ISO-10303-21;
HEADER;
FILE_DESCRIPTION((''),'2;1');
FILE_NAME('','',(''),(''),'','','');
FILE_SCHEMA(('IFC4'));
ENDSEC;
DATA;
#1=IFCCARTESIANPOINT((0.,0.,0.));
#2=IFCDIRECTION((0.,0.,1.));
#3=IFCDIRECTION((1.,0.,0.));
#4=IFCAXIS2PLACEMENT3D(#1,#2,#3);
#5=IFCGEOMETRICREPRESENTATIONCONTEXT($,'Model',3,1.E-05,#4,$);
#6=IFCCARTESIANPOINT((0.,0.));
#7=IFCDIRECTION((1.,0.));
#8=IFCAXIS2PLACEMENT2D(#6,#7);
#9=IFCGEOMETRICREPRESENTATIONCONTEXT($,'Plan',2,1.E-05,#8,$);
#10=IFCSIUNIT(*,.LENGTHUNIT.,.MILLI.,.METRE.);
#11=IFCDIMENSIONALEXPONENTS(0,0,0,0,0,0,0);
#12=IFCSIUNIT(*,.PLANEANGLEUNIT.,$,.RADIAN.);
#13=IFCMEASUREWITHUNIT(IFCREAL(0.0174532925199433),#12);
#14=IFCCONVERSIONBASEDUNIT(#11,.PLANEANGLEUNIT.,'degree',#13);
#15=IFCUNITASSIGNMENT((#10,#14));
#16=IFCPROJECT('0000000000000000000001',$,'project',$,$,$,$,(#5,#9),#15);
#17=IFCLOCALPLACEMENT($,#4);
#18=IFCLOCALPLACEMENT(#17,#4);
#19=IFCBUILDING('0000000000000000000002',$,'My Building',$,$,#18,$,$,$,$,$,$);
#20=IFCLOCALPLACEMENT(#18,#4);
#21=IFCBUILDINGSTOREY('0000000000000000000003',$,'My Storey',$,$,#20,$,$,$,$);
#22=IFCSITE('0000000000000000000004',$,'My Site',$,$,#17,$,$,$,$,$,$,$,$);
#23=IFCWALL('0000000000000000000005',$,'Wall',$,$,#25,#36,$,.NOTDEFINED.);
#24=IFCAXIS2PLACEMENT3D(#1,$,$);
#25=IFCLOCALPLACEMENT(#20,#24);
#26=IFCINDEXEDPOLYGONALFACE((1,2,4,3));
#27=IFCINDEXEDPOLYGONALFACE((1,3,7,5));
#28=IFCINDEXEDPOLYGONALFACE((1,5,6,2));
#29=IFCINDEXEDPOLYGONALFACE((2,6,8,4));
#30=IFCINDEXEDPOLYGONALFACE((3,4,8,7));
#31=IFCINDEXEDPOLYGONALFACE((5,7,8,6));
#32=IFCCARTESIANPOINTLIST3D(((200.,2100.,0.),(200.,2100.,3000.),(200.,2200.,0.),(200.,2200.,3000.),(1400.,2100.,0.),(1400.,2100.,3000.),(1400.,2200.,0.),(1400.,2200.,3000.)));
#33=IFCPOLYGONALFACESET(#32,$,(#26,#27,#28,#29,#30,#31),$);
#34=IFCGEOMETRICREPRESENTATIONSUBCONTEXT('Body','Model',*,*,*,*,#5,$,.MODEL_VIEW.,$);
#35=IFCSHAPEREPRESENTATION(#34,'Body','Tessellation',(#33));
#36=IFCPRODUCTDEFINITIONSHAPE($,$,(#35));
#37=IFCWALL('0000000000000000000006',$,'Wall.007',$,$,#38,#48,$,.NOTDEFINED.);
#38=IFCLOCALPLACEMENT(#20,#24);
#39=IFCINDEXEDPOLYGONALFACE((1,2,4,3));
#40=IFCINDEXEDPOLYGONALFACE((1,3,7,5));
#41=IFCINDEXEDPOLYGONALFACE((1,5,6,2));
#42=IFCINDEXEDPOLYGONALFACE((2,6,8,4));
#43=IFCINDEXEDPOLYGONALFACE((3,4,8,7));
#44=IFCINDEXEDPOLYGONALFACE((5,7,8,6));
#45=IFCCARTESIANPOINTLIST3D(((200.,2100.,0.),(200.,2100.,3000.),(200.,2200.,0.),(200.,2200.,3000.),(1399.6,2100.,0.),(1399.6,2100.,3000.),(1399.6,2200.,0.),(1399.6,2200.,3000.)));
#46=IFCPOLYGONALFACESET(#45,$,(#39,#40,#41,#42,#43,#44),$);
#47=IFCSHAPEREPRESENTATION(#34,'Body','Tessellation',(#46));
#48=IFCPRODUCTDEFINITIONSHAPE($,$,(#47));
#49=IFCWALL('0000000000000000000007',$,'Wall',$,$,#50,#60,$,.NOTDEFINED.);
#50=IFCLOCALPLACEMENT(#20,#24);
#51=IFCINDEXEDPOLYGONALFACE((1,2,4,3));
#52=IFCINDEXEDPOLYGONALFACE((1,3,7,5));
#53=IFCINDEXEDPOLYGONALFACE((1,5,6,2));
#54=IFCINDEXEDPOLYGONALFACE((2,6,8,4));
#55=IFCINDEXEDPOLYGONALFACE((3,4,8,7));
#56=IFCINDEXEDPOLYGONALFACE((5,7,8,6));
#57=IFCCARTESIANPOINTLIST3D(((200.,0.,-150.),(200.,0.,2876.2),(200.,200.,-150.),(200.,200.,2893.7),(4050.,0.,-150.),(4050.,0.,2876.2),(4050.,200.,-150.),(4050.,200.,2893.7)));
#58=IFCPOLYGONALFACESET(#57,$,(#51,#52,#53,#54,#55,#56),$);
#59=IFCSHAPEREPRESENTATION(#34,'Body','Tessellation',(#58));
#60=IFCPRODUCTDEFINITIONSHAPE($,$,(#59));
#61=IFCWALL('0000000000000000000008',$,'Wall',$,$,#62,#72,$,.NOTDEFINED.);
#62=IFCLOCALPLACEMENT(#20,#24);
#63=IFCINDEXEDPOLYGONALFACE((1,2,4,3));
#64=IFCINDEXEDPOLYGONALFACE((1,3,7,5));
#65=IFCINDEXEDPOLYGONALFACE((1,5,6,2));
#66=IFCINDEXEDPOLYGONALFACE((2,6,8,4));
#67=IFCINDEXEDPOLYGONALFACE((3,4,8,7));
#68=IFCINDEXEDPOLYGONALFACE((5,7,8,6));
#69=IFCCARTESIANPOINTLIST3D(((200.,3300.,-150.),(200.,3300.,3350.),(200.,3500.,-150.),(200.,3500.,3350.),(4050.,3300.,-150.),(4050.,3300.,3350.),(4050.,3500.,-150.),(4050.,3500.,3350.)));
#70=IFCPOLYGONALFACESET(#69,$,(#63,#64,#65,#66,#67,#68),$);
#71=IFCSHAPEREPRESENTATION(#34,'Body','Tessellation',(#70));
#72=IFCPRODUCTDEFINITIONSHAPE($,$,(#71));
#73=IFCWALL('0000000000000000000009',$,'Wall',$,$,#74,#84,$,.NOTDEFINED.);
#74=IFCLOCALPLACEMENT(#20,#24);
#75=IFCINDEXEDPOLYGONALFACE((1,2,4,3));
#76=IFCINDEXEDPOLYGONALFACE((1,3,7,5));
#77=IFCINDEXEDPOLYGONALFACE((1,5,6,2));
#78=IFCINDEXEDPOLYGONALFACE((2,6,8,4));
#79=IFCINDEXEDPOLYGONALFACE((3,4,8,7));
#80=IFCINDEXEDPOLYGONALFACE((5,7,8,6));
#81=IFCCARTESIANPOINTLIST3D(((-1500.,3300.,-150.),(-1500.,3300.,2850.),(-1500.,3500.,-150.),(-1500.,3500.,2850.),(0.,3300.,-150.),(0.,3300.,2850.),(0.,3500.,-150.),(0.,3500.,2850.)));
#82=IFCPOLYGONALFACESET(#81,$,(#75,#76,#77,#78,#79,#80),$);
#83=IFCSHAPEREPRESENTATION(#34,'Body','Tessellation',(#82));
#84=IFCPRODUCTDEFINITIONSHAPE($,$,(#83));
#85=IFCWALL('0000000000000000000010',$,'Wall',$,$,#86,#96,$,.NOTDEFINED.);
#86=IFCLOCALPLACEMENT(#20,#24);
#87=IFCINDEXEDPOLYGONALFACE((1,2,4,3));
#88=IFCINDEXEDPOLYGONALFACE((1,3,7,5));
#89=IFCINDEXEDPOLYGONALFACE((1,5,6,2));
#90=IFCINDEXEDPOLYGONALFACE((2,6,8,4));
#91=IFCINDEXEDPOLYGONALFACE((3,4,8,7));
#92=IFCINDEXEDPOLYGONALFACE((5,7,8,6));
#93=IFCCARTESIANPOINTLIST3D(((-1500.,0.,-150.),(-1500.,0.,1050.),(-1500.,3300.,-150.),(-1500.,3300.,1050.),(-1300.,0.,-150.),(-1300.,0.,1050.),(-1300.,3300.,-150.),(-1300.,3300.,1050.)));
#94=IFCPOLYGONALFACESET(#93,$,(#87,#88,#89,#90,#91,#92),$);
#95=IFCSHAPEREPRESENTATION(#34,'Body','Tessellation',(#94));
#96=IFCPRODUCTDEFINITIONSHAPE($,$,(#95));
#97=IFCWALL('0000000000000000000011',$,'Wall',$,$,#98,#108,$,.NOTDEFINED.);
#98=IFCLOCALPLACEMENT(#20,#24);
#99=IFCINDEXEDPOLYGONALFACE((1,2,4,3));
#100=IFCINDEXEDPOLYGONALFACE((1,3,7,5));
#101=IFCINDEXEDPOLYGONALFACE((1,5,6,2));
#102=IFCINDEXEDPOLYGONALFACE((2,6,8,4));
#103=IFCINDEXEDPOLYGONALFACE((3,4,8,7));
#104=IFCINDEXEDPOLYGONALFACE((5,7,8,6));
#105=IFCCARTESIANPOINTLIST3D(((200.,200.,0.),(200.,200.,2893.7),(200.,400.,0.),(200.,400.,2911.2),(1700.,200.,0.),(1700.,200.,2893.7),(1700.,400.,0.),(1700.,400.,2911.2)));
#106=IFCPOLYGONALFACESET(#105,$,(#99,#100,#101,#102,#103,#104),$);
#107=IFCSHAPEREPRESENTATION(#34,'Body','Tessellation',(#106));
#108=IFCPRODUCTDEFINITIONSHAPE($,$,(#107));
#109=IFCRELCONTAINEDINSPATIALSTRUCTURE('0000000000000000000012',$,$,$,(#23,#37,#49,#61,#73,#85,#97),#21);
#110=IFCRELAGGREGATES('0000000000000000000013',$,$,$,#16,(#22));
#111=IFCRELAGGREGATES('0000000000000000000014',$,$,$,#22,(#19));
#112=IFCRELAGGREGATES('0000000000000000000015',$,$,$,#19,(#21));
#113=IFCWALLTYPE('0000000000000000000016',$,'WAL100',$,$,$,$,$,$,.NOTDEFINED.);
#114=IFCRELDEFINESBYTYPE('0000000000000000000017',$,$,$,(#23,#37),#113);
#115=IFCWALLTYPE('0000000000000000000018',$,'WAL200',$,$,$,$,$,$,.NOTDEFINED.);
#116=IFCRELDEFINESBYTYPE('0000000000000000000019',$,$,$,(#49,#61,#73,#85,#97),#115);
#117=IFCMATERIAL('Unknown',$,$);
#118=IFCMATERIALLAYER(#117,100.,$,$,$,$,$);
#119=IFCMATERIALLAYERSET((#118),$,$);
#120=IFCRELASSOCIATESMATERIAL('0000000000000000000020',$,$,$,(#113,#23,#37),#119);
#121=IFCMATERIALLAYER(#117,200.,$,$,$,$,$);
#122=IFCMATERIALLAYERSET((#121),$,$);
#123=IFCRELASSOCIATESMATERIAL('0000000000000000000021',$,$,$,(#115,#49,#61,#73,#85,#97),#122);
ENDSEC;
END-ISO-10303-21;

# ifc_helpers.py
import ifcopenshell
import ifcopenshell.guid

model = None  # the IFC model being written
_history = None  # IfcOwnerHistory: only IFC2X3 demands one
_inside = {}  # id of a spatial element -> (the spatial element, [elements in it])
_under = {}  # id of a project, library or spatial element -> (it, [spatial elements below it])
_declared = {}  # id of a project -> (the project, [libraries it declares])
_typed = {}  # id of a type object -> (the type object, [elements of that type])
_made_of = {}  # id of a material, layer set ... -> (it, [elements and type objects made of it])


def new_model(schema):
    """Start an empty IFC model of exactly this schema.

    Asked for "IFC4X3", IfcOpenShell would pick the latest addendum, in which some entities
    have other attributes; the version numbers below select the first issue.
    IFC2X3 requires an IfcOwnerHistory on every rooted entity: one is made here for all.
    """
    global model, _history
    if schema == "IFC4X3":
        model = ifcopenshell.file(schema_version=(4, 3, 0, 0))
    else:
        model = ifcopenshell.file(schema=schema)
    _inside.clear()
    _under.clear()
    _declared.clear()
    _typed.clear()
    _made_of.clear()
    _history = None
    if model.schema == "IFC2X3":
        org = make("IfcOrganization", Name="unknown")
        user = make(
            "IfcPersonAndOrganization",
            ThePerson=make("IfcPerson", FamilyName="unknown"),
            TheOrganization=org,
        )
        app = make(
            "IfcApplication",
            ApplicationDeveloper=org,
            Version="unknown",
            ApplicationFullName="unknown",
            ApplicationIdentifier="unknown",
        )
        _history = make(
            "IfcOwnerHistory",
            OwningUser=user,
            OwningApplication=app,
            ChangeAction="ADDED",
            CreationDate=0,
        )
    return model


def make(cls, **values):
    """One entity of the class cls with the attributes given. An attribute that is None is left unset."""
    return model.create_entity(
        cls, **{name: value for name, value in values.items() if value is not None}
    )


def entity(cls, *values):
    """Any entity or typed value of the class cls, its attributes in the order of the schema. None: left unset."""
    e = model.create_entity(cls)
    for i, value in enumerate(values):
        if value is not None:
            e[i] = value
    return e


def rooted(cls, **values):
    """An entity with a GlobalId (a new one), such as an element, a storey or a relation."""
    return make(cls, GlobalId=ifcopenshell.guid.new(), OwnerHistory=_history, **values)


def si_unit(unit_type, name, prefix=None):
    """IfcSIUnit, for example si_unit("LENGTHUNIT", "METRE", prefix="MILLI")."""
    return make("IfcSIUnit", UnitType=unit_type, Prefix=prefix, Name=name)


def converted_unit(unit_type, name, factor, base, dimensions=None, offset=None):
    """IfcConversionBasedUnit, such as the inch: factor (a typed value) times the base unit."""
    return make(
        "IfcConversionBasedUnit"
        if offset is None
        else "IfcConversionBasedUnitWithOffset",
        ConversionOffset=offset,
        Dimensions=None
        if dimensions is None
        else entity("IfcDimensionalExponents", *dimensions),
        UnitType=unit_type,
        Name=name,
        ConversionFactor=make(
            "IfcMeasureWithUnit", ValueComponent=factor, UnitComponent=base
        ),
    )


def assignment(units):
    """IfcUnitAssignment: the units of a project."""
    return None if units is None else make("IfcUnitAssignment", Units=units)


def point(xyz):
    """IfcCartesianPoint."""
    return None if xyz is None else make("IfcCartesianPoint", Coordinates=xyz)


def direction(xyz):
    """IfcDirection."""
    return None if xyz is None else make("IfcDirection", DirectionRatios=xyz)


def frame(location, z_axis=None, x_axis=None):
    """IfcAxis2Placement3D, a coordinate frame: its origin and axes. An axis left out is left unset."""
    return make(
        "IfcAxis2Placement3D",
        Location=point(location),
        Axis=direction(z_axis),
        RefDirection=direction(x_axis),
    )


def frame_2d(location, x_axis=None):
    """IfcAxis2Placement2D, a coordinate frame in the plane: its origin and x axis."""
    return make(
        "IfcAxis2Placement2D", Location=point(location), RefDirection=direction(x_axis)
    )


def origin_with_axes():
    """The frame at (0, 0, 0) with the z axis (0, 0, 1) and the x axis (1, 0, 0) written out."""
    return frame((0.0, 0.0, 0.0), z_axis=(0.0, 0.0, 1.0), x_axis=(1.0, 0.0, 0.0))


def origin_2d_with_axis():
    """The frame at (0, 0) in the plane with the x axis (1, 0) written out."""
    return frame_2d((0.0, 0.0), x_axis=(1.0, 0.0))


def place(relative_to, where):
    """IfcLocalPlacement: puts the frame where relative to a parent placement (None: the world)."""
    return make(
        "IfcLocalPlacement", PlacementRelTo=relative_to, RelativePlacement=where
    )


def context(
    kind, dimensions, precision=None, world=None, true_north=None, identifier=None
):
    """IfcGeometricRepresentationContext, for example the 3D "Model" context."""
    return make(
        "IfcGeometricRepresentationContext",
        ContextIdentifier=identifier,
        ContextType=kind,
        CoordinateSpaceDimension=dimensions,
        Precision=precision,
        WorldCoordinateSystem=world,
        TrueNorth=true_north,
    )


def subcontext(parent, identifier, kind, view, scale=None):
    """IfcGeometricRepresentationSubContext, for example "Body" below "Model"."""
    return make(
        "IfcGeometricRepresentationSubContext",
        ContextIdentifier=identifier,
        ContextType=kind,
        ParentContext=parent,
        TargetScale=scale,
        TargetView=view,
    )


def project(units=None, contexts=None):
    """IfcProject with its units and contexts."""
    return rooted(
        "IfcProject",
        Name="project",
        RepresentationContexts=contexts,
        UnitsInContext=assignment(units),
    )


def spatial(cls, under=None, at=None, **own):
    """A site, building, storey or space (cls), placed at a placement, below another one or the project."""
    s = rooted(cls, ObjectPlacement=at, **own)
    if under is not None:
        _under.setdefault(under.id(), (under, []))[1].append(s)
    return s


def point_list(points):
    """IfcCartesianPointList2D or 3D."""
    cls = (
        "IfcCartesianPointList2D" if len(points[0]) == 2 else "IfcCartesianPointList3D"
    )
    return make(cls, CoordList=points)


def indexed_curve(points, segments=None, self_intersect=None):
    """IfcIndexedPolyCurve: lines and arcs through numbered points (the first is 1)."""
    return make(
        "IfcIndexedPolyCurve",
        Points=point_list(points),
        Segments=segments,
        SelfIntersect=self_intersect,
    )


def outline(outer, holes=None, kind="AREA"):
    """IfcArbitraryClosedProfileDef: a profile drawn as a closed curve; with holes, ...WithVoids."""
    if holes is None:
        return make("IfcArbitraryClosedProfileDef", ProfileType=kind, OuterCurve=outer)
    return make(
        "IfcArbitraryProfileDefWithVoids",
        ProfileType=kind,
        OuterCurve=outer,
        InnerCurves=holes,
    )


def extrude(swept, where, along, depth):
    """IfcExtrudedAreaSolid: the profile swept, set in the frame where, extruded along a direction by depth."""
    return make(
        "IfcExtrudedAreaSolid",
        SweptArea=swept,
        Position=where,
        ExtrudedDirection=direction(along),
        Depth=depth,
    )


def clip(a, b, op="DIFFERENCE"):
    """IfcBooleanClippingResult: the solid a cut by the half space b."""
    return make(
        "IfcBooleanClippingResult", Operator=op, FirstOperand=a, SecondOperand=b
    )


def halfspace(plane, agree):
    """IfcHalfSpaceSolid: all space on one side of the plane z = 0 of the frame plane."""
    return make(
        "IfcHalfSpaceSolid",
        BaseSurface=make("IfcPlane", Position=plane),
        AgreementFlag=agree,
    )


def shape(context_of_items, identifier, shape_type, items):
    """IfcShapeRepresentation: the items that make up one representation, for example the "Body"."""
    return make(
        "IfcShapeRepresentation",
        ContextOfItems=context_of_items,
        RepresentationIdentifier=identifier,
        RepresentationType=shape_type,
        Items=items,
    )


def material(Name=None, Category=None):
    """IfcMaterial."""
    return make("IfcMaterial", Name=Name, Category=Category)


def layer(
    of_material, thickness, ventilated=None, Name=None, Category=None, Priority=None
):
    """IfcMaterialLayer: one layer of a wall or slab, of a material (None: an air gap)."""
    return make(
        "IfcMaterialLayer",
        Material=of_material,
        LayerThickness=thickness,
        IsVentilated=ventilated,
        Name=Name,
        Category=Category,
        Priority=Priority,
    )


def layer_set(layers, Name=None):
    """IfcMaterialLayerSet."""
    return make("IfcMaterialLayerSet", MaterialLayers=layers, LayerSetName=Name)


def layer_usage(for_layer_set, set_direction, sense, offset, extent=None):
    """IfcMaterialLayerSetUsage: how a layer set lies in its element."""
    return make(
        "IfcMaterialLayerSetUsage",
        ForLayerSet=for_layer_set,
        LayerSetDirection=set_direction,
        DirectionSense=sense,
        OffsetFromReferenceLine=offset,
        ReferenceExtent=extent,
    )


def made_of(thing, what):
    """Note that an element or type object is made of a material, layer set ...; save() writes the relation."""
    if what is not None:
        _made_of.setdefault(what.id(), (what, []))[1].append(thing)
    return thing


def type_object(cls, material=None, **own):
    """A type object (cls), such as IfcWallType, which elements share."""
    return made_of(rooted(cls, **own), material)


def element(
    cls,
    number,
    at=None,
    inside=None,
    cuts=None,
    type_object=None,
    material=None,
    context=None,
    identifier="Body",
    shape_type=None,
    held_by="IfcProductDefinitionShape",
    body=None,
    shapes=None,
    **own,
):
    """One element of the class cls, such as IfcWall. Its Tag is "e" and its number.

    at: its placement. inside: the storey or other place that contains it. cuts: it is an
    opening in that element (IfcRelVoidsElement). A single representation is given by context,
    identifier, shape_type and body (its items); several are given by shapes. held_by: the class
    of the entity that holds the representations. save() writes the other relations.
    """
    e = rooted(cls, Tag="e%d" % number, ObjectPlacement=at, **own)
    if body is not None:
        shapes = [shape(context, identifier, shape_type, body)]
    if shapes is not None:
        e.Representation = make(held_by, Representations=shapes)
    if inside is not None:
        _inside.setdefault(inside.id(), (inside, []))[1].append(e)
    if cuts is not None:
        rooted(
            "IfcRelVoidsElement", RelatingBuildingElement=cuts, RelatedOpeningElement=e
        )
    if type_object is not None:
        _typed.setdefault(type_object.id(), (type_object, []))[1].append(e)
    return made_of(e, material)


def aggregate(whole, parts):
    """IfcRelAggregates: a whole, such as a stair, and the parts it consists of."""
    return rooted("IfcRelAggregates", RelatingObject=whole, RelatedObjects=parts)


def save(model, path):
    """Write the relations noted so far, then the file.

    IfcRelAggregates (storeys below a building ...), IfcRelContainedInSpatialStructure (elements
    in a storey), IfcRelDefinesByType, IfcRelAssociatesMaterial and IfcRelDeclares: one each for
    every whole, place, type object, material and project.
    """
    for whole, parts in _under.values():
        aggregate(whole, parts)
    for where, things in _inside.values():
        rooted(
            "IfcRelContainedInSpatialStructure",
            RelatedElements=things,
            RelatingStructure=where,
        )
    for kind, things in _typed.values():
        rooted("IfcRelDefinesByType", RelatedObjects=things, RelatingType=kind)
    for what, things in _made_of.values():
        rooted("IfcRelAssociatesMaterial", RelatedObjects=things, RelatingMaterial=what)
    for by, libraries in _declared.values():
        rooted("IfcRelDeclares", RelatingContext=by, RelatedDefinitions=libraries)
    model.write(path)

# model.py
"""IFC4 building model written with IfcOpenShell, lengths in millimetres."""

from ifc_helpers import new_model, entity, si_unit, converted_unit, frame, origin_with_axes, origin_2d_with_axis, place, context, subcontext, project, spatial, indexed_curve, outline, extrude, clip, halfspace, material, layer, layer_set, layer_usage, type_object, element, save


model = new_model("IFC4")

# Units and contexts
model_context = context("Model", 3, precision=1e-05, world=origin_with_axes())
plan_context = context("Plan", 2, precision=1e-05, world=origin_2d_with_axis())
body_context = subcontext(model_context, "Body", "Model", "MODEL_VIEW")
ifc_project = project(units=[si_unit("LENGTHUNIT", "METRE", prefix="MILLI"), converted_unit("PLANEANGLEUNIT", "degree", entity("IfcReal", 0.0174532925199433), si_unit("PLANEANGLEUNIT", "RADIAN"), dimensions=[0, 0, 0, 0, 0, 0, 0])], contexts=[model_context, plan_context])

# Site, building, storey
site_placement = place(None, origin_with_axes())
site = spatial("IfcSite", under=ifc_project, at=site_placement, Name="My Site")
building_placement = place(site_placement, origin_with_axes())
building = spatial("IfcBuilding", under=site, at=building_placement, Name="My Building")
storey_placement = place(building_placement, origin_with_axes())
storey = spatial("IfcBuildingStorey", under=building, at=storey_placement, Name="My Storey")

# Shared definitions
ifc_material = material(Name="Unknown")

# Walls
ifc_layer_1 = layer(ifc_material, 100.0)
ifc_layer_set_1 = layer_set([ifc_layer_1])
ifc_layer_usage_1 = layer_usage(ifc_layer_set_1, "AXIS2", "POSITIVE", 0.0)
wall_type_1 = type_object("IfcWallType", Name="WAL100", PredefinedType="NOTDEFINED", material=ifc_layer_set_1)
wall_1_placement = place(storey_placement, frame((200.0, 2100.0, 0.0), z_axis=(0.0, 0.0, 1.0), x_axis=(1.0, 0.0, 0.0)))
element("IfcWall", 1, at=wall_1_placement, inside=storey, type_object=wall_type_1, material=ifc_layer_usage_1, Name="Wall", PredefinedType="NOTDEFINED", context=body_context, shape_type="SweptSolid", body=[
    extrude(outline(indexed_curve([(0.0, 0.0), (0.0, 100.0), (1200.0, 100.0), (1200.0, 0.0), (0.0, 0.0)], self_intersect=False)), origin_with_axes(), (0.0, 0.0, 1.0), 3000.0),
])
ifc_layer_usage_2 = layer_usage(ifc_layer_set_1, "AXIS2", "POSITIVE", 0.0)
wall_2_placement = place(storey_placement, frame((1399.6, 2200.0, 0.0), z_axis=(0.0, 0.0, 1.0), x_axis=(-1.0, 0.0, 0.0)))
element("IfcWall", 2, at=wall_2_placement, inside=storey, type_object=wall_type_1, material=ifc_layer_usage_2, Name="Wall.007", PredefinedType="NOTDEFINED", context=body_context, shape_type="SweptSolid", body=[
    extrude(outline(indexed_curve([(0.0, 0.0), (0.0, 100.0), (1199.6, 100.0), (1199.6, 0.0), (0.0, 0.0)], self_intersect=False)), origin_with_axes(), (0.0, 0.0, 1.0), 3000.0),
])
ifc_layer_2 = layer(ifc_material, 200.0)
ifc_layer_set_2 = layer_set([ifc_layer_2])
ifc_layer_usage_3 = layer_usage(ifc_layer_set_2, "AXIS2", "POSITIVE", 0.0)
wall_type_2 = type_object("IfcWallType", Name="WAL200", PredefinedType="NOTDEFINED", material=ifc_layer_set_2)
wall_3_placement = place(storey_placement, frame((200.0, 0.0, -150.0), z_axis=(0.0, 0.0, 1.0), x_axis=(1.0, 0.0, 0.0)))
element("IfcWall", 3, at=wall_3_placement, inside=storey, type_object=wall_type_2, material=ifc_layer_usage_3, Name="Wall", PredefinedType="NOTDEFINED", context=body_context, shape_type="Clipping", body=[
    clip(extrude(outline(indexed_curve([(0.0, 0.0), (0.0, 200.0), (3850.0, 200.0), (3850.0, 0.0), (0.0, 0.0)], self_intersect=False)), origin_with_axes(), (0.0, 0.0, 1.0), 3043.7), halfspace(frame((0.0, 200.0, 3043.7), z_axis=(0.0, -0.087156, 0.996195), x_axis=(1.0, 0.0, 0.0)), False)),
])
ifc_layer_usage_4 = layer_usage(ifc_layer_set_2, "AXIS2", "POSITIVE", 0.0)
wall_4_placement = place(storey_placement, frame((4050.0, 3500.0, -150.0), z_axis=(0.0, 0.0, 1.0), x_axis=(-1.0, 0.0, 0.0)))
element("IfcWall", 4, at=wall_4_placement, inside=storey, type_object=wall_type_2, material=ifc_layer_usage_4, Name="Wall", PredefinedType="NOTDEFINED", context=body_context, shape_type="SweptSolid", body=[
    extrude(outline(indexed_curve([(0.0, 0.0), (0.0, 200.0), (3850.0, 200.0), (3850.0, 0.0), (0.0, 0.0)], self_intersect=False)), origin_with_axes(), (0.0, 0.0, 1.0), 3500.0),
])
ifc_layer_usage_5 = layer_usage(ifc_layer_set_2, "AXIS2", "POSITIVE", 0.0)
wall_5_placement = place(storey_placement, frame((0.0, 3500.0, -150.0), z_axis=(0.0, 0.0, 1.0), x_axis=(-1.0, 0.0, 0.0)))
element("IfcWall", 5, at=wall_5_placement, inside=storey, type_object=wall_type_2, material=ifc_layer_usage_5, Name="Wall", PredefinedType="NOTDEFINED", context=body_context, shape_type="SweptSolid", body=[
    extrude(outline(indexed_curve([(0.0, 0.0), (0.0, 200.0), (1500.0, 200.0), (1500.0, 0.0), (0.0, 0.0)], self_intersect=False)), origin_with_axes(), (0.0, 0.0, 1.0), 3000.0),
])
ifc_layer_usage_6 = layer_usage(ifc_layer_set_2, "AXIS2", "POSITIVE", 0.0)
wall_6_placement = place(storey_placement, frame((-1500.0, 3300.0, -150.0), z_axis=(0.0, 0.0, 1.0), x_axis=(0.0, -1.0, 0.0)))
element("IfcWall", 6, at=wall_6_placement, inside=storey, type_object=wall_type_2, material=ifc_layer_usage_6, Name="Wall", PredefinedType="NOTDEFINED", context=body_context, shape_type="SweptSolid", body=[
    extrude(outline(indexed_curve([(0.0, 0.0), (0.0, 200.0), (3300.0, 200.0), (3300.0, 0.0), (0.0, 0.0)], self_intersect=False)), origin_with_axes(), (0.0, 0.0, 1.0), 1200.0),
])
ifc_layer_usage_7 = layer_usage(ifc_layer_set_2, "AXIS2", "POSITIVE", 0.0)
wall_7_placement = place(storey_placement, frame((200.0, 200.0, 0.0), z_axis=(0.0, 0.0, 1.0), x_axis=(1.0, 0.0, 0.0)))
element("IfcWall", 7, at=wall_7_placement, inside=storey, type_object=wall_type_2, material=ifc_layer_usage_7, Name="Wall", PredefinedType="NOTDEFINED", context=body_context, shape_type="Clipping", body=[
    clip(extrude(outline(indexed_curve([(0.0, 0.0), (0.0, 200.0), (1500.0, 200.0), (1500.0, 0.0), (0.0, 0.0)], self_intersect=False)), origin_with_axes(), (0.0, 0.0, 1.0), 2911.2), halfspace(frame((0.0, 200.0, 2911.2), z_axis=(0.0, -0.087156, 0.996195), x_axis=(1.0, 0.0, 0.0)), False)),
])

save(model, "model.ifc")
